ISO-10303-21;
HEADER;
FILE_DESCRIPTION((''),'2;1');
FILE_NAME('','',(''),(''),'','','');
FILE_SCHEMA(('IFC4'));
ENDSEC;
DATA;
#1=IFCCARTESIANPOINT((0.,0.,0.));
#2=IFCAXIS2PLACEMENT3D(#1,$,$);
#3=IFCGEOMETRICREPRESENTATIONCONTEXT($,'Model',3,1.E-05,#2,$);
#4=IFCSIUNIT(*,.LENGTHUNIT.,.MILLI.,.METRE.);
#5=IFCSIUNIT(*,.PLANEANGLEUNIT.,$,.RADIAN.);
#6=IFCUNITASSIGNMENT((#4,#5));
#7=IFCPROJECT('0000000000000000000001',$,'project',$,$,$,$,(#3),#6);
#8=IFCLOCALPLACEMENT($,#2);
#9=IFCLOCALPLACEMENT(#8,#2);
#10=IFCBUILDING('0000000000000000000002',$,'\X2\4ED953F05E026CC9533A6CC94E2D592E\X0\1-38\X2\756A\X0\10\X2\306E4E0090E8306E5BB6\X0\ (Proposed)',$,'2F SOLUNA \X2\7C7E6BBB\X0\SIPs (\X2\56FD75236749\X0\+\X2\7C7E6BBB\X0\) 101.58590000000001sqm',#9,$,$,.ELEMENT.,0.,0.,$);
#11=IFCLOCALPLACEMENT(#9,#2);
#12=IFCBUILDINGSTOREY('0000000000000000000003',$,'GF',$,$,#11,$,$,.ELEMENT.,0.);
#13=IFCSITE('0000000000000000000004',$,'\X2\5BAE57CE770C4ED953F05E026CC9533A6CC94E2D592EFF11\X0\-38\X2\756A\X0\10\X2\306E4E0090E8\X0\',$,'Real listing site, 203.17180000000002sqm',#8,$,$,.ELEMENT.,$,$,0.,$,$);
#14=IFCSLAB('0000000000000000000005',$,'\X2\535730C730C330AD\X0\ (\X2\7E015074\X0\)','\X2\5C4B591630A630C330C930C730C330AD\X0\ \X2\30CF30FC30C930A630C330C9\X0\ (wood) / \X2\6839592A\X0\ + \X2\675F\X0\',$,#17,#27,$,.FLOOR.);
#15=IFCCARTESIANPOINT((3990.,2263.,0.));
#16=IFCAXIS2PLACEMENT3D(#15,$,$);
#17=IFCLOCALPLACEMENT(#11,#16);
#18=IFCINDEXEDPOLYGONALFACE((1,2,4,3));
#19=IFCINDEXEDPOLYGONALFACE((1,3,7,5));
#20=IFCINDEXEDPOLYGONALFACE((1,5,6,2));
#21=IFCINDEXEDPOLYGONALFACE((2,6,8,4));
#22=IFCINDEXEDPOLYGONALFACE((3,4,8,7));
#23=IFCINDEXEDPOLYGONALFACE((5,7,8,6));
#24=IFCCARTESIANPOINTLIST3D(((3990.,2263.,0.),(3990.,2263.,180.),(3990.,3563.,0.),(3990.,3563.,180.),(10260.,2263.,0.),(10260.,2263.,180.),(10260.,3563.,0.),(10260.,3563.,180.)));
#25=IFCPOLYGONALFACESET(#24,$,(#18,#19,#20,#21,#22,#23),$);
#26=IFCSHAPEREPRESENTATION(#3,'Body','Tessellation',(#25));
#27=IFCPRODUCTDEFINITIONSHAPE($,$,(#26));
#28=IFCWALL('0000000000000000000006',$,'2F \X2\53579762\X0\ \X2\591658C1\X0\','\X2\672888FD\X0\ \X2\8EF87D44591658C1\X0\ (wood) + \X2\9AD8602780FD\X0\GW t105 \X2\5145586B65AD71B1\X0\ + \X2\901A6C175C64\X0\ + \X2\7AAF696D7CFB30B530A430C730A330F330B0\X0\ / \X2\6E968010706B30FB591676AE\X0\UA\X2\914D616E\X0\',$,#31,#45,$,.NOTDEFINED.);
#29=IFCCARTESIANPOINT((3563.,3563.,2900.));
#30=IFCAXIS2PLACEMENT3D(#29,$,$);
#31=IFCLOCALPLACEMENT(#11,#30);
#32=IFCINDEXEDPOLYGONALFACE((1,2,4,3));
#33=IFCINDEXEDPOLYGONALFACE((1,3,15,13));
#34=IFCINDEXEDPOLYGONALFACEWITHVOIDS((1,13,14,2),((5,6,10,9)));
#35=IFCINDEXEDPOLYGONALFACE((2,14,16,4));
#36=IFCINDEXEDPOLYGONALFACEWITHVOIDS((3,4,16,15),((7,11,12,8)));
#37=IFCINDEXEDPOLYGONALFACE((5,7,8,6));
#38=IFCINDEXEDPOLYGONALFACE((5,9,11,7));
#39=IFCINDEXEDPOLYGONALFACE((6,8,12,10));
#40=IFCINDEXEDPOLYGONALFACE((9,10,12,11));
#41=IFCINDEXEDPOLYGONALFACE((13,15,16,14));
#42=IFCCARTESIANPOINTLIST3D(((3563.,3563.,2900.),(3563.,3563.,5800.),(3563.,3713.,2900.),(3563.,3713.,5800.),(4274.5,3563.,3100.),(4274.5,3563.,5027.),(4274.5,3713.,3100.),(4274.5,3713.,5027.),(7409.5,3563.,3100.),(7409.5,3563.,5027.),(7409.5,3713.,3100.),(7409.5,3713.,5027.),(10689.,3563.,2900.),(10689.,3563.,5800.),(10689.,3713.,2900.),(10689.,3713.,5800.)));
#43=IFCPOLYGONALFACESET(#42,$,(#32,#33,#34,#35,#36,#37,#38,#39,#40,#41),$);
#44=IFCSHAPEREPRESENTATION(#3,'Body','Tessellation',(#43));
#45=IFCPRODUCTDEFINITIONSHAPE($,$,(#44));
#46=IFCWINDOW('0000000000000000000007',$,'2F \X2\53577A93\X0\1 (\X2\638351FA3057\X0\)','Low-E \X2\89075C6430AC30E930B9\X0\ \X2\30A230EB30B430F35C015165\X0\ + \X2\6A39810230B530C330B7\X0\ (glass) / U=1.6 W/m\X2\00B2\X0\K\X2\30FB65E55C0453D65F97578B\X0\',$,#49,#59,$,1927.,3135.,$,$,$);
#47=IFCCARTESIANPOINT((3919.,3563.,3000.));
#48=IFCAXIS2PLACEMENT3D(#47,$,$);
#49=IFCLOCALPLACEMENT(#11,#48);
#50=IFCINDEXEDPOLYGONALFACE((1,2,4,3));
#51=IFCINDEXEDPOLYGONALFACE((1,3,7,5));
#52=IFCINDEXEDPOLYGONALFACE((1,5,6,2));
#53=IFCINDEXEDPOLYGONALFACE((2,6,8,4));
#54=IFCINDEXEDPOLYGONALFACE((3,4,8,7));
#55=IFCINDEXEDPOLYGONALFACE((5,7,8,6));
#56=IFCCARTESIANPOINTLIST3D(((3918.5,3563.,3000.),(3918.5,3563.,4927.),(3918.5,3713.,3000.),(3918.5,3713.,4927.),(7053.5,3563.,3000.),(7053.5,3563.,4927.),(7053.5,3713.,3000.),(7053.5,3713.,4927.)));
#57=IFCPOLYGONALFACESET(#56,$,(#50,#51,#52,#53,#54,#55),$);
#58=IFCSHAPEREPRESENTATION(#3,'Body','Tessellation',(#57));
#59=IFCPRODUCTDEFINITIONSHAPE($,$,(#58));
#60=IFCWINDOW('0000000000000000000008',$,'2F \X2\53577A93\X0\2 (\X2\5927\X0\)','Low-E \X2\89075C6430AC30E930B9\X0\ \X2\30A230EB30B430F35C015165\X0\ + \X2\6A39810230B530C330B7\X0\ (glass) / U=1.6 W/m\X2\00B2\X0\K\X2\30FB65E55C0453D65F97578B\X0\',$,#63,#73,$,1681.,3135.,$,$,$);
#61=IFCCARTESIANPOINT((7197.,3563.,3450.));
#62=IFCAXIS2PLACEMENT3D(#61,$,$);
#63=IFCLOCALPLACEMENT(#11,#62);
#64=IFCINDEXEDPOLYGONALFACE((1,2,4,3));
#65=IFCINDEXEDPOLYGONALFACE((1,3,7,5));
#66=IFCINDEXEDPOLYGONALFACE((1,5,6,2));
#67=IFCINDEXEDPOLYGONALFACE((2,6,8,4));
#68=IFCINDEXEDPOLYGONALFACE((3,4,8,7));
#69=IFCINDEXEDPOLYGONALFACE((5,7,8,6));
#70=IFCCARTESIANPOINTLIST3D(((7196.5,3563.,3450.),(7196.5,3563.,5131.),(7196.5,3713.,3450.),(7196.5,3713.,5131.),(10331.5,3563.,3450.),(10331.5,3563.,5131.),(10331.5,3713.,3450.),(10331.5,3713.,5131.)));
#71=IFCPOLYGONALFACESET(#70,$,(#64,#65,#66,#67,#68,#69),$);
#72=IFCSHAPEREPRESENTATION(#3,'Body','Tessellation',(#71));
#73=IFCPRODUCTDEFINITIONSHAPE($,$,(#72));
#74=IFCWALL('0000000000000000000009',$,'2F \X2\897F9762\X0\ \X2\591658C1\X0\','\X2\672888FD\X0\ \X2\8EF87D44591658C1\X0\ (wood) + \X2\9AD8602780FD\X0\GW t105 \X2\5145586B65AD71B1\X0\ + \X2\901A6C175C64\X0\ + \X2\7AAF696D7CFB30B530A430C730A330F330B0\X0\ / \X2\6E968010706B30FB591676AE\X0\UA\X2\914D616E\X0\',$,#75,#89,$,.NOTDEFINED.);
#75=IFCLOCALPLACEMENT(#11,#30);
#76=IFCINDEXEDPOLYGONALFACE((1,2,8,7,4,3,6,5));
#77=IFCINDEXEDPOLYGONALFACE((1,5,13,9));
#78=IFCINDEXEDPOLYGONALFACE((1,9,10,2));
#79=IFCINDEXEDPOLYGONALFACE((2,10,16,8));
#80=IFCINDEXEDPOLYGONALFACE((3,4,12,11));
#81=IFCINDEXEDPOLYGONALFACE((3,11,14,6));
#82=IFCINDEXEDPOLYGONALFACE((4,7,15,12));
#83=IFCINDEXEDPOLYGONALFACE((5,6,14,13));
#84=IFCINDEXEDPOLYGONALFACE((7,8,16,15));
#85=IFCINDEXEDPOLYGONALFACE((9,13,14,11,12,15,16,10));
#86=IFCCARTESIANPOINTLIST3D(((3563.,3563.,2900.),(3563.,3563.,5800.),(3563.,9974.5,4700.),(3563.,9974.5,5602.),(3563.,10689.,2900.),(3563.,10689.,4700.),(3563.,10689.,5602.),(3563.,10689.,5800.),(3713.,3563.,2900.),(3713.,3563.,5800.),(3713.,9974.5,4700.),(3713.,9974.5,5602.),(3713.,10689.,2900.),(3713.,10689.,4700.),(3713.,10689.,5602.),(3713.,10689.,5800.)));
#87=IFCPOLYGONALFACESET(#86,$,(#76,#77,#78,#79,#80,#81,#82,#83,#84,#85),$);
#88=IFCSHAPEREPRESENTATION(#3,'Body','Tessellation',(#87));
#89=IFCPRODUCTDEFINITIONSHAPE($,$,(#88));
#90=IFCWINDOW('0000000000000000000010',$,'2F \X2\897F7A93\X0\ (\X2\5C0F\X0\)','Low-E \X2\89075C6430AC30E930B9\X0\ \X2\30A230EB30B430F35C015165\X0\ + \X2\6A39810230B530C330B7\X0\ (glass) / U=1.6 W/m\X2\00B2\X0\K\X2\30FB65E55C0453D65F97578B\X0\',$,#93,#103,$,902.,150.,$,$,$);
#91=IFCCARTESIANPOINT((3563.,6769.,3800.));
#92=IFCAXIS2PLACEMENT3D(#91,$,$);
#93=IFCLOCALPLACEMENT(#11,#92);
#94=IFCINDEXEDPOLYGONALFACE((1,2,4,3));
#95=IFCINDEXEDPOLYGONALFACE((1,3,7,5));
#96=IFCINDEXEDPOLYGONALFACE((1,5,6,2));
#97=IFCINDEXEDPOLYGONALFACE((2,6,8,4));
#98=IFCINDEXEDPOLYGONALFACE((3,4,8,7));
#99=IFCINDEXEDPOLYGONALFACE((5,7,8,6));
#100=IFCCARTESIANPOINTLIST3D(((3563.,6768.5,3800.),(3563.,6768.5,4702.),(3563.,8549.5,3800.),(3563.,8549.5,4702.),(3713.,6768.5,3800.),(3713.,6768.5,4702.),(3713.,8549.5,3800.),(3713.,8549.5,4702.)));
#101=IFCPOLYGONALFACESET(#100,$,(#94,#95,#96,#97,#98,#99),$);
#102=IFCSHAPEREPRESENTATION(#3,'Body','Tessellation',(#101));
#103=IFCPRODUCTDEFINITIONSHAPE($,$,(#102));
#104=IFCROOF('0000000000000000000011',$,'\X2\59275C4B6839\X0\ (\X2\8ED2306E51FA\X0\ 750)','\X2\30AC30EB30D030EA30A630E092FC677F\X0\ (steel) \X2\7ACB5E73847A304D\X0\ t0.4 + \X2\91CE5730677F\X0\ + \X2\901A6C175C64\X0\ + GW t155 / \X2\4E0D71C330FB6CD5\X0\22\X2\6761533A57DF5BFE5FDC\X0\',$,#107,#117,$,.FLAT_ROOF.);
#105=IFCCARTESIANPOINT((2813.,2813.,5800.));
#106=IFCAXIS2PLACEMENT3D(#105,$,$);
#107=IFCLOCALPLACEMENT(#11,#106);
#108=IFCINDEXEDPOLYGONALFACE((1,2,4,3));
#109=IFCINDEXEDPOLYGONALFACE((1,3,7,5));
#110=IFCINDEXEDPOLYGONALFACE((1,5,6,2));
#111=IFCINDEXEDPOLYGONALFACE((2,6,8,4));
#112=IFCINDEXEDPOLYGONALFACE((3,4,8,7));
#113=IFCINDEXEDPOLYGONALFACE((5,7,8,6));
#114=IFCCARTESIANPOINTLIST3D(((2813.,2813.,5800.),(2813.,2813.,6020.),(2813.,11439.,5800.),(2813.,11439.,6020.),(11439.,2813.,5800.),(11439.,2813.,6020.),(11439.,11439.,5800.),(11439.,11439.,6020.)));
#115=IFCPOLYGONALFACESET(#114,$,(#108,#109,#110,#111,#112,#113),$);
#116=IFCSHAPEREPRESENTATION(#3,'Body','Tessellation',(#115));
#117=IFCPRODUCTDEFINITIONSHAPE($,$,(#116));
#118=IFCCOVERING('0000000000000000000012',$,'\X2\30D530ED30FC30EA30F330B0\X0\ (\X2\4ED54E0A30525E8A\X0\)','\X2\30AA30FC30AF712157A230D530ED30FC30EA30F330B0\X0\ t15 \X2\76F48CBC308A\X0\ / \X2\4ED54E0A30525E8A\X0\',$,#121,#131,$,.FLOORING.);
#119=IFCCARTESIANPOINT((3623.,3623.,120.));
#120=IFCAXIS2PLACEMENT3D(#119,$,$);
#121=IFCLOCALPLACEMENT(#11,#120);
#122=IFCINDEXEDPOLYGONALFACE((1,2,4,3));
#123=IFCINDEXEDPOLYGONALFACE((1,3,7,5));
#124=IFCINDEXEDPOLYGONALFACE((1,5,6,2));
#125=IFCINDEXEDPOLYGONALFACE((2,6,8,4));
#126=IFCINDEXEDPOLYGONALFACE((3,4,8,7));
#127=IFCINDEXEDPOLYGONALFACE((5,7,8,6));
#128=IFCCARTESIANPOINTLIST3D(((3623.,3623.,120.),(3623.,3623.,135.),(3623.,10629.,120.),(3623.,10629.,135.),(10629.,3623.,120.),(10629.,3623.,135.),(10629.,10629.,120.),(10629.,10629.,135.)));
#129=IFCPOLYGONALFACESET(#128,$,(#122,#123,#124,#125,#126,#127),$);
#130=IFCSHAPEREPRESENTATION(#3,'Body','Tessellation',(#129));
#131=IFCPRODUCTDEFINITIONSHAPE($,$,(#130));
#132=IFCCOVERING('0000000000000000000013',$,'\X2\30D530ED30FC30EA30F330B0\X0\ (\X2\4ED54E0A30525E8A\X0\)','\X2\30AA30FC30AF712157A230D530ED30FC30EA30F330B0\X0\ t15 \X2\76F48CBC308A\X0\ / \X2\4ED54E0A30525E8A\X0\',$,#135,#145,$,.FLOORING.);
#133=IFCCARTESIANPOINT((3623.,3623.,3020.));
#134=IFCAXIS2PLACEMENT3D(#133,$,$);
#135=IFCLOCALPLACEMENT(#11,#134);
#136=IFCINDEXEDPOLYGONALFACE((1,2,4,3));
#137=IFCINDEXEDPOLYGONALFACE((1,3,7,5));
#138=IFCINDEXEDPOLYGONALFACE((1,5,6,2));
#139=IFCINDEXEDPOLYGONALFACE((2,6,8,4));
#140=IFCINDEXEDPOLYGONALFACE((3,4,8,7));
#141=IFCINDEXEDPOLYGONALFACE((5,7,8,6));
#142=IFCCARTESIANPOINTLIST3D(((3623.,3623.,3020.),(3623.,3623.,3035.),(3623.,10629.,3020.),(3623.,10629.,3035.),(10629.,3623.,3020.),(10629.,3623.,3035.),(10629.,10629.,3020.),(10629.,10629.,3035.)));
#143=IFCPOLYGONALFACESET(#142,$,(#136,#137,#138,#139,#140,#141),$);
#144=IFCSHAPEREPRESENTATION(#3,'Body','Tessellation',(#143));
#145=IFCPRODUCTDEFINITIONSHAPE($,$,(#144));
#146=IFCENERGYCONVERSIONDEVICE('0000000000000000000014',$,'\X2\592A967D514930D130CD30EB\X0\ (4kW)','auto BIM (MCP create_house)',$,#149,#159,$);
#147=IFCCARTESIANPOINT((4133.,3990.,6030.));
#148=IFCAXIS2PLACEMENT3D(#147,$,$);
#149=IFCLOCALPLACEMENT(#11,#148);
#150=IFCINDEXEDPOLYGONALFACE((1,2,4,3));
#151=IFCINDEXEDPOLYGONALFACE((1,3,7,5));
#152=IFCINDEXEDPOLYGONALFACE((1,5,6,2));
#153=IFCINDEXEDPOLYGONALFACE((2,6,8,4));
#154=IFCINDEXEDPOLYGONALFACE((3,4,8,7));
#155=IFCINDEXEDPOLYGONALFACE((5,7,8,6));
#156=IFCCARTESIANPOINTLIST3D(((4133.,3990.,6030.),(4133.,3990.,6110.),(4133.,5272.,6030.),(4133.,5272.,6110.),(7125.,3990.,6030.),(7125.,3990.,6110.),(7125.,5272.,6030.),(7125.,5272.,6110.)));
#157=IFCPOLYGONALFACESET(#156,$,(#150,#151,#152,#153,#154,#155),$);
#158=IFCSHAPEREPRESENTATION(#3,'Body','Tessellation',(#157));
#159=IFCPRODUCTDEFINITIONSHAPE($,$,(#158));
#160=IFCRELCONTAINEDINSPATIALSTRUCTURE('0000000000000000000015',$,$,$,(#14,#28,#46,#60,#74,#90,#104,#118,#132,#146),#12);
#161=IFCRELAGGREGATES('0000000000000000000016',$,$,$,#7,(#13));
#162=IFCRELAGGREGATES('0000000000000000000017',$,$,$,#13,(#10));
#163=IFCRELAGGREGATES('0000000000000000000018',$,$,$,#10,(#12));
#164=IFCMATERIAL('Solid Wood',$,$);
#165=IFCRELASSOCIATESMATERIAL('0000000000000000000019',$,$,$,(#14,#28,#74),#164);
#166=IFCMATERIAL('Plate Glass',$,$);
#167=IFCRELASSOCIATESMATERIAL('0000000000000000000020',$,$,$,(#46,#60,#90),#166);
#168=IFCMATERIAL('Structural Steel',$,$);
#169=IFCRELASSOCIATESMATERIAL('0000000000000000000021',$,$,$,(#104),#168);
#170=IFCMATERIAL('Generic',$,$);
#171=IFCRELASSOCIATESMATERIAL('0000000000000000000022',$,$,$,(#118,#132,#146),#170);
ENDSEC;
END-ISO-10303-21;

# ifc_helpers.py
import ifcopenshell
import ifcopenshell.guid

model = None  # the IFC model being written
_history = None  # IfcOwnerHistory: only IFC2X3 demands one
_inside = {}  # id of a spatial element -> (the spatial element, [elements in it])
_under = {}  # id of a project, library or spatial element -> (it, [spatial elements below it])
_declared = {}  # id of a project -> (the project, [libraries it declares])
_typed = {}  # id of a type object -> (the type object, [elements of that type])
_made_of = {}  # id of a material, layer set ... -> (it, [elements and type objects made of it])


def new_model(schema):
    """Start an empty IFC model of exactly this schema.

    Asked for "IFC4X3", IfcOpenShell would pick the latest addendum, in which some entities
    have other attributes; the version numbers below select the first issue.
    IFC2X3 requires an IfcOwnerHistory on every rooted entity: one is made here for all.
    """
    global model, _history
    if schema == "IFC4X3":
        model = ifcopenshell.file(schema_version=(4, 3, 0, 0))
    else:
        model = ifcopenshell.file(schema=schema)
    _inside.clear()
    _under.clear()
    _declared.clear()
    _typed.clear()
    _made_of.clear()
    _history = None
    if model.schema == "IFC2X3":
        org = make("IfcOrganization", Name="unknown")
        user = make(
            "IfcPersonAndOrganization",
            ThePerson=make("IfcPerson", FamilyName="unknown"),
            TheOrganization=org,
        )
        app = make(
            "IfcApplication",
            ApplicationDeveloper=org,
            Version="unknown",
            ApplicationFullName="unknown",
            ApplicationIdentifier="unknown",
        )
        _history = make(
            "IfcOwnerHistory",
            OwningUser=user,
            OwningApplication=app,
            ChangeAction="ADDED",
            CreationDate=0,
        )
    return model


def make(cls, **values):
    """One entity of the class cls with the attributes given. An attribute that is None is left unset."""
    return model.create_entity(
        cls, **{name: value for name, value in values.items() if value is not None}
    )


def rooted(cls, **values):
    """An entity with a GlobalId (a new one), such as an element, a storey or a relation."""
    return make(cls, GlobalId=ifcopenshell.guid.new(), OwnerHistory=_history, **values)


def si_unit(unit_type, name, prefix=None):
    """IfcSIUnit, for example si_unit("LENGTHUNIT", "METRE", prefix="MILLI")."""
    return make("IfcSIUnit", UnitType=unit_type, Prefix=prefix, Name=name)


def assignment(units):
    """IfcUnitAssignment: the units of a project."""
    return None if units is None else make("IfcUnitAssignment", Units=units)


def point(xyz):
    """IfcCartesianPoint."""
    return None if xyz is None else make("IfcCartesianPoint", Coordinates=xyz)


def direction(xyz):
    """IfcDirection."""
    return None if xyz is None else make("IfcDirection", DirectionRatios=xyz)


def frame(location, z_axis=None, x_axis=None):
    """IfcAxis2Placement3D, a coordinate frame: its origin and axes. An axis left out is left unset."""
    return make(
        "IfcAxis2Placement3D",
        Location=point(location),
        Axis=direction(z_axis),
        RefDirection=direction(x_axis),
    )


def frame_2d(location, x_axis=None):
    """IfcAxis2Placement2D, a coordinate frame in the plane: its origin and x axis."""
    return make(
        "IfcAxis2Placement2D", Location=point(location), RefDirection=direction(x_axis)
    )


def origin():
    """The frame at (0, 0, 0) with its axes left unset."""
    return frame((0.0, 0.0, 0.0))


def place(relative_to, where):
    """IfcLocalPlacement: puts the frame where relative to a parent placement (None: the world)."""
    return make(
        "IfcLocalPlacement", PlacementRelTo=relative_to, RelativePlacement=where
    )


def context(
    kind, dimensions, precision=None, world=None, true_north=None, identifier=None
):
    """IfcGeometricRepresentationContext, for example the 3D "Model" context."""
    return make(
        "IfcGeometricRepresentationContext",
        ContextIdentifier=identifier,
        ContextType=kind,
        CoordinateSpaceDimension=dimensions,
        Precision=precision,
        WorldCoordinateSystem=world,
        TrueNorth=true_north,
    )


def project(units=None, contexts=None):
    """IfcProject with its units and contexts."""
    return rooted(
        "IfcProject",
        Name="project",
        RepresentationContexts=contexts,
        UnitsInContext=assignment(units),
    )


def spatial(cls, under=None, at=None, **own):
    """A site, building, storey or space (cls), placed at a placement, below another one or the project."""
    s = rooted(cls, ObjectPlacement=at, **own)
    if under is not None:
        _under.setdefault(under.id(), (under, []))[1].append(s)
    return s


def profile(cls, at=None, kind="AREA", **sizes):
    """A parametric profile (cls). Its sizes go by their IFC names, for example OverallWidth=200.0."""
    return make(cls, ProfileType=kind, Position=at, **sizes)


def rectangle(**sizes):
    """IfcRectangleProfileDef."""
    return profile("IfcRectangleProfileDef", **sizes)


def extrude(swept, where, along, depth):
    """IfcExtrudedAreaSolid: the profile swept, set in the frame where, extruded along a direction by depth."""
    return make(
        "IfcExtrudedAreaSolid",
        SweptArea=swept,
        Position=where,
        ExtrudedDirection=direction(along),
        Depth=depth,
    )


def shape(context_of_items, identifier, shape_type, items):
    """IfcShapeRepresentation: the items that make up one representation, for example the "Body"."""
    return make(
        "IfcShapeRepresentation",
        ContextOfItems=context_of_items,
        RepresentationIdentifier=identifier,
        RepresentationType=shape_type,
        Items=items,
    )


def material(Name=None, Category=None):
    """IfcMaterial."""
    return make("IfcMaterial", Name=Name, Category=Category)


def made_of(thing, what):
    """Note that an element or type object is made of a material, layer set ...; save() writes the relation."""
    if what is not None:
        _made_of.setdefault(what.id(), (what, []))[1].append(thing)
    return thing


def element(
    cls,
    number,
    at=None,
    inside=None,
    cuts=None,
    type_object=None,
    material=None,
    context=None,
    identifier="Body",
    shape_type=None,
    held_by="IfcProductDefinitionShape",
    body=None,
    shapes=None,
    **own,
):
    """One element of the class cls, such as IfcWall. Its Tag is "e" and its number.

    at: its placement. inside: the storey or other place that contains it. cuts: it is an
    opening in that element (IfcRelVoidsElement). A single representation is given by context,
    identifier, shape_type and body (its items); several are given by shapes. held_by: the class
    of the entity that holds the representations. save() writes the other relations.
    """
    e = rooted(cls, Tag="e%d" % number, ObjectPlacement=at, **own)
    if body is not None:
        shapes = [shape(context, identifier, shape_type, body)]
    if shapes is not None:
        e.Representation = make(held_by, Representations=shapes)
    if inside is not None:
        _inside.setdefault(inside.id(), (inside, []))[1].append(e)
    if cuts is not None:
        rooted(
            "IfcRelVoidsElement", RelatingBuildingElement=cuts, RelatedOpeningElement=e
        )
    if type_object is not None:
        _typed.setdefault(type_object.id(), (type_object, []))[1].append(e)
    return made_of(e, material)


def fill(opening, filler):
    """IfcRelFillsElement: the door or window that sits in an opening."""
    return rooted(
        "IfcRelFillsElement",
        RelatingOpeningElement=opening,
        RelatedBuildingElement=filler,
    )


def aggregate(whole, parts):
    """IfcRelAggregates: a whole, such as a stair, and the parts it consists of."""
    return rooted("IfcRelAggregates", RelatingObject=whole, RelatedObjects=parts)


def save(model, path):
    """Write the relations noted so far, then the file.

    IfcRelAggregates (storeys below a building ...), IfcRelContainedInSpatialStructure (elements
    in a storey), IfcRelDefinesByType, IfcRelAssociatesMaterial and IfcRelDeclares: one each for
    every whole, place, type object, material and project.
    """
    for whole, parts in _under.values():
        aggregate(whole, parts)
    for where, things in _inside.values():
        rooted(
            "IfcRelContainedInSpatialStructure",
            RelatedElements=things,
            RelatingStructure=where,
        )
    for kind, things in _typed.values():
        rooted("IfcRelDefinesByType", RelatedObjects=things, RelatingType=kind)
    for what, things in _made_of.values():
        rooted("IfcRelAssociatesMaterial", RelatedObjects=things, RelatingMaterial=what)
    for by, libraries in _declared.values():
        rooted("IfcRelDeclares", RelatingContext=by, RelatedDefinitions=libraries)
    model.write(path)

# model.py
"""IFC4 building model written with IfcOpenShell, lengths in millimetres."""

from ifc_helpers import new_model, si_unit, frame, frame_2d, origin, place, context, project, spatial, rectangle, extrude, material, element, fill, save


model = new_model("IFC4")

# Units and contexts
model_context = context("Model", 3, precision=1e-05, world=origin())
ifc_project = project(units=[si_unit("LENGTHUNIT", "METRE", prefix="MILLI"), si_unit("PLANEANGLEUNIT", "RADIAN")], contexts=[model_context])

# Site, building, storey
site_placement = place(None, origin())
site = spatial("IfcSite", under=ifc_project, at=site_placement, Name="宮城県仙台市泉区泉中央１-38番10の一部", ObjectType="Real listing site, 203.17180000000002sqm", CompositionType="ELEMENT", RefElevation=0.0)
building_placement = place(site_placement, origin())
building = spatial("IfcBuilding", under=site, at=building_placement, Name="仙台市泉区泉中央1-38番10の一部の家 (Proposed)", ObjectType="2F SOLUNA 籾殻SIPs (国産杉+籾殻) 101.58590000000001sqm", CompositionType="ELEMENT", ElevationOfRefHeight=0.0, ElevationOfTerrain=0.0)
storey_placement = place(building_placement, origin())
storey = spatial("IfcBuildingStorey", under=building, at=storey_placement, Name="GF", CompositionType="ELEMENT", Elevation=0.0)

# Slab
ifc_material_1 = material(Name="Solid Wood")
slab_1_placement = place(storey_placement, frame((3990.0, 2263.0, 0.0)))
element("IfcSlab", 1, at=slab_1_placement, inside=storey, material=ifc_material_1, Name="南デッキ (縁側)", Description="屋外ウッドデッキ ハードウッド (wood) / 根太 + 束", PredefinedType="FLOOR", context=model_context, shape_type="SweptSolid", body=[
    extrude(rectangle(XDim=6270.0, YDim=1300.0, at=frame_2d((3135.0, 650.0))), frame((3990.0, 2263.0, 0.0)), (0.0, 0.0, 1.0), 180.0),
])

# Shared definitions
ifc_material_2 = material(Name="Plate Glass")

# Wall, openings, windows
wall_1_placement = place(storey_placement, frame((3563.0, 3563.0, 2900.0)))
wall_1 = element("IfcWall", 2, at=wall_1_placement, inside=storey, material=ifc_material_1, Name="2F 南面 外壁", Description="木製 軸組外壁 (wood) + 高性能GW t105 充填断熱 + 通気層 + 窯業系サイディング / 準耐火・外皮UA配慮", PredefinedType="NOTDEFINED", context=model_context, shape_type="SweptSolid", body=[
    extrude(rectangle(XDim=7126.0, YDim=150.0, at=frame_2d((3563.0, 75.0))), frame((3563.0, 3563.0, 2900.0)), (0.0, 0.0, 1.0), 2900.0),
])
opening_1_placement = place(storey_placement, frame((3919.0, 3563.0, 3000.0)))
opening_1 = element("IfcOpeningElement", 3, at=opening_1_placement, cuts=wall_1, PredefinedType="NOTDEFINED", context=model_context, shape_type="SweptSolid", body=[
    extrude(rectangle(XDim=3135.0, YDim=150.0, at=frame_2d((1567.0, 75.0))), frame((3919.0, 3563.0, 3000.0)), (0.0, 0.0, 1.0), 1927.0),
])
opening_2_placement = place(storey_placement, frame((7197.0, 3563.0, 3450.0)))
opening_2 = element("IfcOpeningElement", 4, at=opening_2_placement, cuts=wall_1, PredefinedType="NOTDEFINED", context=model_context, shape_type="SweptSolid", body=[
    extrude(rectangle(XDim=3135.0, YDim=150.0, at=frame_2d((1567.0, 75.0))), frame((7197.0, 3563.0, 3450.0)), (0.0, 0.0, 1.0), 1681.0),
])
window_1_placement = place(storey_placement, frame((3919.0, 3563.0, 3000.0)))
window_1 = element("IfcWindow", 5, at=window_1_placement, inside=storey, material=ifc_material_2, Name="2F 南窓1 (掃出し)", Description="Low-E 複層ガラス アルゴン封入 + 樹脂サッシ (glass) / U=1.6 W/m²K・日射取得型", OverallHeight=1927.0, OverallWidth=3135.0, context=model_context, shape_type="SweptSolid", body=[
    extrude(rectangle(XDim=3135.0, YDim=150.0, at=frame_2d((1567.0, 75.0))), frame((3919.0, 3563.0, 3000.0)), (0.0, 0.0, 1.0), 1927.0),
])
fill(opening_1, window_1)
window_2_placement = place(storey_placement, frame((7197.0, 3563.0, 3450.0)))
window_2 = element("IfcWindow", 6, at=window_2_placement, inside=storey, material=ifc_material_2, Name="2F 南窓2 (大)", Description="Low-E 複層ガラス アルゴン封入 + 樹脂サッシ (glass) / U=1.6 W/m²K・日射取得型", OverallHeight=1681.0, OverallWidth=3135.0, context=model_context, shape_type="SweptSolid", body=[
    extrude(rectangle(XDim=3135.0, YDim=150.0, at=frame_2d((1567.0, 75.0))), frame((7197.0, 3563.0, 3450.0)), (0.0, 0.0, 1.0), 1681.0),
])
fill(opening_2, window_2)

# Wall, opening, window
wall_2_placement = place(storey_placement, frame((3563.0, 3563.0, 2900.0)))
wall_2 = element("IfcWall", 7, at=wall_2_placement, inside=storey, material=ifc_material_1, Name="2F 西面 外壁", Description="木製 軸組外壁 (wood) + 高性能GW t105 充填断熱 + 通気層 + 窯業系サイディング / 準耐火・外皮UA配慮", PredefinedType="NOTDEFINED", context=model_context, shape_type="SweptSolid", body=[
    extrude(rectangle(XDim=150.0, YDim=7126.0, at=frame_2d((75.0, 3563.0))), frame((3563.0, 3563.0, 2900.0)), (0.0, 0.0, 1.0), 2900.0),
])
opening_3_placement = place(storey_placement, frame((3563.0, 6769.0, 3800.0)))
opening_3 = element("IfcOpeningElement", 8, at=opening_3_placement, cuts=wall_2, PredefinedType="NOTDEFINED", context=model_context, shape_type="SweptSolid", body=[
    extrude(rectangle(XDim=150.0, YDim=1781.0, at=frame_2d((75.0, 890.0))), frame((3563.0, 6769.0, 3800.0)), (0.0, 0.0, 1.0), 902.0),
])
window_3_placement = place(storey_placement, frame((3563.0, 6769.0, 3800.0)))
window_3 = element("IfcWindow", 9, at=window_3_placement, inside=storey, material=ifc_material_2, Name="2F 西窓 (小)", Description="Low-E 複層ガラス アルゴン封入 + 樹脂サッシ (glass) / U=1.6 W/m²K・日射取得型", OverallHeight=902.0, OverallWidth=150.0, context=model_context, shape_type="SweptSolid", body=[
    extrude(rectangle(XDim=150.0, YDim=1781.0, at=frame_2d((75.0, 890.0))), frame((3563.0, 6769.0, 3800.0)), (0.0, 0.0, 1.0), 902.0),
])
fill(opening_3, window_3)

# Roof
ifc_material_3 = material(Name="Structural Steel")
roof_placement = place(storey_placement, frame((2813.0, 2813.0, 5800.0)))
element("IfcRoof", 10, at=roof_placement, inside=storey, material=ifc_material_3, Name="大屋根 (軒の出 750)", Description="ガルバリウム鋼板 (steel) 立平葺き t0.4 + 野地板 + 通気層 + GW t155 / 不燃・法22条区域対応", PredefinedType="FLAT_ROOF", context=model_context, shape_type="SweptSolid", body=[
    extrude(rectangle(XDim=8626.0, YDim=8626.0, at=frame_2d((4313.0, 4313.0))), frame((2813.0, 2813.0, 5800.0)), (0.0, 0.0, 1.0), 220.0),
])

# Coverings
ifc_material_4 = material(Name="Generic")
covering_1_placement = place(storey_placement, frame((3623.0, 3623.0, 120.0)))
element("IfcCovering", 11, at=covering_1_placement, inside=storey, material=ifc_material_4, Name="フローリング (仕上げ床)", Description="オーク無垢フローリング t15 直貼り / 仕上げ床", PredefinedType="FLOORING", context=model_context, shape_type="SweptSolid", body=[
    extrude(rectangle(XDim=7006.0, YDim=7006.0, at=frame_2d((3503.0, 3503.0))), frame((3623.0, 3623.0, 120.0)), (0.0, 0.0, 1.0), 15.0),
])
covering_2_placement = place(storey_placement, frame((3623.0, 3623.0, 3020.0)))
element("IfcCovering", 12, at=covering_2_placement, inside=storey, material=ifc_material_4, Name="フローリング (仕上げ床)", Description="オーク無垢フローリング t15 直貼り / 仕上げ床", PredefinedType="FLOORING", context=model_context, shape_type="SweptSolid", body=[
    extrude(rectangle(XDim=7006.0, YDim=7006.0, at=frame_2d((3503.0, 3503.0))), frame((3623.0, 3623.0, 3020.0)), (0.0, 0.0, 1.0), 15.0),
])

# Energy conversion device
energy_conversion_device_placement = place(storey_placement, frame((4133.0, 3990.0, 6030.0)))
element("IfcEnergyConversionDevice", 13, at=energy_conversion_device_placement, inside=storey, material=ifc_material_4, Name="太陽光パネル (4kW)", Description="auto BIM (MCP create_house)", context=model_context, shape_type="SweptSolid", body=[
    extrude(rectangle(XDim=2992.0, YDim=1282.0, at=frame_2d((1496.0, 641.0))), frame((4133.0, 3990.0, 6030.0)), (0.0, 0.0, 1.0), 80.0),
])

save(model, "model.ifc")
